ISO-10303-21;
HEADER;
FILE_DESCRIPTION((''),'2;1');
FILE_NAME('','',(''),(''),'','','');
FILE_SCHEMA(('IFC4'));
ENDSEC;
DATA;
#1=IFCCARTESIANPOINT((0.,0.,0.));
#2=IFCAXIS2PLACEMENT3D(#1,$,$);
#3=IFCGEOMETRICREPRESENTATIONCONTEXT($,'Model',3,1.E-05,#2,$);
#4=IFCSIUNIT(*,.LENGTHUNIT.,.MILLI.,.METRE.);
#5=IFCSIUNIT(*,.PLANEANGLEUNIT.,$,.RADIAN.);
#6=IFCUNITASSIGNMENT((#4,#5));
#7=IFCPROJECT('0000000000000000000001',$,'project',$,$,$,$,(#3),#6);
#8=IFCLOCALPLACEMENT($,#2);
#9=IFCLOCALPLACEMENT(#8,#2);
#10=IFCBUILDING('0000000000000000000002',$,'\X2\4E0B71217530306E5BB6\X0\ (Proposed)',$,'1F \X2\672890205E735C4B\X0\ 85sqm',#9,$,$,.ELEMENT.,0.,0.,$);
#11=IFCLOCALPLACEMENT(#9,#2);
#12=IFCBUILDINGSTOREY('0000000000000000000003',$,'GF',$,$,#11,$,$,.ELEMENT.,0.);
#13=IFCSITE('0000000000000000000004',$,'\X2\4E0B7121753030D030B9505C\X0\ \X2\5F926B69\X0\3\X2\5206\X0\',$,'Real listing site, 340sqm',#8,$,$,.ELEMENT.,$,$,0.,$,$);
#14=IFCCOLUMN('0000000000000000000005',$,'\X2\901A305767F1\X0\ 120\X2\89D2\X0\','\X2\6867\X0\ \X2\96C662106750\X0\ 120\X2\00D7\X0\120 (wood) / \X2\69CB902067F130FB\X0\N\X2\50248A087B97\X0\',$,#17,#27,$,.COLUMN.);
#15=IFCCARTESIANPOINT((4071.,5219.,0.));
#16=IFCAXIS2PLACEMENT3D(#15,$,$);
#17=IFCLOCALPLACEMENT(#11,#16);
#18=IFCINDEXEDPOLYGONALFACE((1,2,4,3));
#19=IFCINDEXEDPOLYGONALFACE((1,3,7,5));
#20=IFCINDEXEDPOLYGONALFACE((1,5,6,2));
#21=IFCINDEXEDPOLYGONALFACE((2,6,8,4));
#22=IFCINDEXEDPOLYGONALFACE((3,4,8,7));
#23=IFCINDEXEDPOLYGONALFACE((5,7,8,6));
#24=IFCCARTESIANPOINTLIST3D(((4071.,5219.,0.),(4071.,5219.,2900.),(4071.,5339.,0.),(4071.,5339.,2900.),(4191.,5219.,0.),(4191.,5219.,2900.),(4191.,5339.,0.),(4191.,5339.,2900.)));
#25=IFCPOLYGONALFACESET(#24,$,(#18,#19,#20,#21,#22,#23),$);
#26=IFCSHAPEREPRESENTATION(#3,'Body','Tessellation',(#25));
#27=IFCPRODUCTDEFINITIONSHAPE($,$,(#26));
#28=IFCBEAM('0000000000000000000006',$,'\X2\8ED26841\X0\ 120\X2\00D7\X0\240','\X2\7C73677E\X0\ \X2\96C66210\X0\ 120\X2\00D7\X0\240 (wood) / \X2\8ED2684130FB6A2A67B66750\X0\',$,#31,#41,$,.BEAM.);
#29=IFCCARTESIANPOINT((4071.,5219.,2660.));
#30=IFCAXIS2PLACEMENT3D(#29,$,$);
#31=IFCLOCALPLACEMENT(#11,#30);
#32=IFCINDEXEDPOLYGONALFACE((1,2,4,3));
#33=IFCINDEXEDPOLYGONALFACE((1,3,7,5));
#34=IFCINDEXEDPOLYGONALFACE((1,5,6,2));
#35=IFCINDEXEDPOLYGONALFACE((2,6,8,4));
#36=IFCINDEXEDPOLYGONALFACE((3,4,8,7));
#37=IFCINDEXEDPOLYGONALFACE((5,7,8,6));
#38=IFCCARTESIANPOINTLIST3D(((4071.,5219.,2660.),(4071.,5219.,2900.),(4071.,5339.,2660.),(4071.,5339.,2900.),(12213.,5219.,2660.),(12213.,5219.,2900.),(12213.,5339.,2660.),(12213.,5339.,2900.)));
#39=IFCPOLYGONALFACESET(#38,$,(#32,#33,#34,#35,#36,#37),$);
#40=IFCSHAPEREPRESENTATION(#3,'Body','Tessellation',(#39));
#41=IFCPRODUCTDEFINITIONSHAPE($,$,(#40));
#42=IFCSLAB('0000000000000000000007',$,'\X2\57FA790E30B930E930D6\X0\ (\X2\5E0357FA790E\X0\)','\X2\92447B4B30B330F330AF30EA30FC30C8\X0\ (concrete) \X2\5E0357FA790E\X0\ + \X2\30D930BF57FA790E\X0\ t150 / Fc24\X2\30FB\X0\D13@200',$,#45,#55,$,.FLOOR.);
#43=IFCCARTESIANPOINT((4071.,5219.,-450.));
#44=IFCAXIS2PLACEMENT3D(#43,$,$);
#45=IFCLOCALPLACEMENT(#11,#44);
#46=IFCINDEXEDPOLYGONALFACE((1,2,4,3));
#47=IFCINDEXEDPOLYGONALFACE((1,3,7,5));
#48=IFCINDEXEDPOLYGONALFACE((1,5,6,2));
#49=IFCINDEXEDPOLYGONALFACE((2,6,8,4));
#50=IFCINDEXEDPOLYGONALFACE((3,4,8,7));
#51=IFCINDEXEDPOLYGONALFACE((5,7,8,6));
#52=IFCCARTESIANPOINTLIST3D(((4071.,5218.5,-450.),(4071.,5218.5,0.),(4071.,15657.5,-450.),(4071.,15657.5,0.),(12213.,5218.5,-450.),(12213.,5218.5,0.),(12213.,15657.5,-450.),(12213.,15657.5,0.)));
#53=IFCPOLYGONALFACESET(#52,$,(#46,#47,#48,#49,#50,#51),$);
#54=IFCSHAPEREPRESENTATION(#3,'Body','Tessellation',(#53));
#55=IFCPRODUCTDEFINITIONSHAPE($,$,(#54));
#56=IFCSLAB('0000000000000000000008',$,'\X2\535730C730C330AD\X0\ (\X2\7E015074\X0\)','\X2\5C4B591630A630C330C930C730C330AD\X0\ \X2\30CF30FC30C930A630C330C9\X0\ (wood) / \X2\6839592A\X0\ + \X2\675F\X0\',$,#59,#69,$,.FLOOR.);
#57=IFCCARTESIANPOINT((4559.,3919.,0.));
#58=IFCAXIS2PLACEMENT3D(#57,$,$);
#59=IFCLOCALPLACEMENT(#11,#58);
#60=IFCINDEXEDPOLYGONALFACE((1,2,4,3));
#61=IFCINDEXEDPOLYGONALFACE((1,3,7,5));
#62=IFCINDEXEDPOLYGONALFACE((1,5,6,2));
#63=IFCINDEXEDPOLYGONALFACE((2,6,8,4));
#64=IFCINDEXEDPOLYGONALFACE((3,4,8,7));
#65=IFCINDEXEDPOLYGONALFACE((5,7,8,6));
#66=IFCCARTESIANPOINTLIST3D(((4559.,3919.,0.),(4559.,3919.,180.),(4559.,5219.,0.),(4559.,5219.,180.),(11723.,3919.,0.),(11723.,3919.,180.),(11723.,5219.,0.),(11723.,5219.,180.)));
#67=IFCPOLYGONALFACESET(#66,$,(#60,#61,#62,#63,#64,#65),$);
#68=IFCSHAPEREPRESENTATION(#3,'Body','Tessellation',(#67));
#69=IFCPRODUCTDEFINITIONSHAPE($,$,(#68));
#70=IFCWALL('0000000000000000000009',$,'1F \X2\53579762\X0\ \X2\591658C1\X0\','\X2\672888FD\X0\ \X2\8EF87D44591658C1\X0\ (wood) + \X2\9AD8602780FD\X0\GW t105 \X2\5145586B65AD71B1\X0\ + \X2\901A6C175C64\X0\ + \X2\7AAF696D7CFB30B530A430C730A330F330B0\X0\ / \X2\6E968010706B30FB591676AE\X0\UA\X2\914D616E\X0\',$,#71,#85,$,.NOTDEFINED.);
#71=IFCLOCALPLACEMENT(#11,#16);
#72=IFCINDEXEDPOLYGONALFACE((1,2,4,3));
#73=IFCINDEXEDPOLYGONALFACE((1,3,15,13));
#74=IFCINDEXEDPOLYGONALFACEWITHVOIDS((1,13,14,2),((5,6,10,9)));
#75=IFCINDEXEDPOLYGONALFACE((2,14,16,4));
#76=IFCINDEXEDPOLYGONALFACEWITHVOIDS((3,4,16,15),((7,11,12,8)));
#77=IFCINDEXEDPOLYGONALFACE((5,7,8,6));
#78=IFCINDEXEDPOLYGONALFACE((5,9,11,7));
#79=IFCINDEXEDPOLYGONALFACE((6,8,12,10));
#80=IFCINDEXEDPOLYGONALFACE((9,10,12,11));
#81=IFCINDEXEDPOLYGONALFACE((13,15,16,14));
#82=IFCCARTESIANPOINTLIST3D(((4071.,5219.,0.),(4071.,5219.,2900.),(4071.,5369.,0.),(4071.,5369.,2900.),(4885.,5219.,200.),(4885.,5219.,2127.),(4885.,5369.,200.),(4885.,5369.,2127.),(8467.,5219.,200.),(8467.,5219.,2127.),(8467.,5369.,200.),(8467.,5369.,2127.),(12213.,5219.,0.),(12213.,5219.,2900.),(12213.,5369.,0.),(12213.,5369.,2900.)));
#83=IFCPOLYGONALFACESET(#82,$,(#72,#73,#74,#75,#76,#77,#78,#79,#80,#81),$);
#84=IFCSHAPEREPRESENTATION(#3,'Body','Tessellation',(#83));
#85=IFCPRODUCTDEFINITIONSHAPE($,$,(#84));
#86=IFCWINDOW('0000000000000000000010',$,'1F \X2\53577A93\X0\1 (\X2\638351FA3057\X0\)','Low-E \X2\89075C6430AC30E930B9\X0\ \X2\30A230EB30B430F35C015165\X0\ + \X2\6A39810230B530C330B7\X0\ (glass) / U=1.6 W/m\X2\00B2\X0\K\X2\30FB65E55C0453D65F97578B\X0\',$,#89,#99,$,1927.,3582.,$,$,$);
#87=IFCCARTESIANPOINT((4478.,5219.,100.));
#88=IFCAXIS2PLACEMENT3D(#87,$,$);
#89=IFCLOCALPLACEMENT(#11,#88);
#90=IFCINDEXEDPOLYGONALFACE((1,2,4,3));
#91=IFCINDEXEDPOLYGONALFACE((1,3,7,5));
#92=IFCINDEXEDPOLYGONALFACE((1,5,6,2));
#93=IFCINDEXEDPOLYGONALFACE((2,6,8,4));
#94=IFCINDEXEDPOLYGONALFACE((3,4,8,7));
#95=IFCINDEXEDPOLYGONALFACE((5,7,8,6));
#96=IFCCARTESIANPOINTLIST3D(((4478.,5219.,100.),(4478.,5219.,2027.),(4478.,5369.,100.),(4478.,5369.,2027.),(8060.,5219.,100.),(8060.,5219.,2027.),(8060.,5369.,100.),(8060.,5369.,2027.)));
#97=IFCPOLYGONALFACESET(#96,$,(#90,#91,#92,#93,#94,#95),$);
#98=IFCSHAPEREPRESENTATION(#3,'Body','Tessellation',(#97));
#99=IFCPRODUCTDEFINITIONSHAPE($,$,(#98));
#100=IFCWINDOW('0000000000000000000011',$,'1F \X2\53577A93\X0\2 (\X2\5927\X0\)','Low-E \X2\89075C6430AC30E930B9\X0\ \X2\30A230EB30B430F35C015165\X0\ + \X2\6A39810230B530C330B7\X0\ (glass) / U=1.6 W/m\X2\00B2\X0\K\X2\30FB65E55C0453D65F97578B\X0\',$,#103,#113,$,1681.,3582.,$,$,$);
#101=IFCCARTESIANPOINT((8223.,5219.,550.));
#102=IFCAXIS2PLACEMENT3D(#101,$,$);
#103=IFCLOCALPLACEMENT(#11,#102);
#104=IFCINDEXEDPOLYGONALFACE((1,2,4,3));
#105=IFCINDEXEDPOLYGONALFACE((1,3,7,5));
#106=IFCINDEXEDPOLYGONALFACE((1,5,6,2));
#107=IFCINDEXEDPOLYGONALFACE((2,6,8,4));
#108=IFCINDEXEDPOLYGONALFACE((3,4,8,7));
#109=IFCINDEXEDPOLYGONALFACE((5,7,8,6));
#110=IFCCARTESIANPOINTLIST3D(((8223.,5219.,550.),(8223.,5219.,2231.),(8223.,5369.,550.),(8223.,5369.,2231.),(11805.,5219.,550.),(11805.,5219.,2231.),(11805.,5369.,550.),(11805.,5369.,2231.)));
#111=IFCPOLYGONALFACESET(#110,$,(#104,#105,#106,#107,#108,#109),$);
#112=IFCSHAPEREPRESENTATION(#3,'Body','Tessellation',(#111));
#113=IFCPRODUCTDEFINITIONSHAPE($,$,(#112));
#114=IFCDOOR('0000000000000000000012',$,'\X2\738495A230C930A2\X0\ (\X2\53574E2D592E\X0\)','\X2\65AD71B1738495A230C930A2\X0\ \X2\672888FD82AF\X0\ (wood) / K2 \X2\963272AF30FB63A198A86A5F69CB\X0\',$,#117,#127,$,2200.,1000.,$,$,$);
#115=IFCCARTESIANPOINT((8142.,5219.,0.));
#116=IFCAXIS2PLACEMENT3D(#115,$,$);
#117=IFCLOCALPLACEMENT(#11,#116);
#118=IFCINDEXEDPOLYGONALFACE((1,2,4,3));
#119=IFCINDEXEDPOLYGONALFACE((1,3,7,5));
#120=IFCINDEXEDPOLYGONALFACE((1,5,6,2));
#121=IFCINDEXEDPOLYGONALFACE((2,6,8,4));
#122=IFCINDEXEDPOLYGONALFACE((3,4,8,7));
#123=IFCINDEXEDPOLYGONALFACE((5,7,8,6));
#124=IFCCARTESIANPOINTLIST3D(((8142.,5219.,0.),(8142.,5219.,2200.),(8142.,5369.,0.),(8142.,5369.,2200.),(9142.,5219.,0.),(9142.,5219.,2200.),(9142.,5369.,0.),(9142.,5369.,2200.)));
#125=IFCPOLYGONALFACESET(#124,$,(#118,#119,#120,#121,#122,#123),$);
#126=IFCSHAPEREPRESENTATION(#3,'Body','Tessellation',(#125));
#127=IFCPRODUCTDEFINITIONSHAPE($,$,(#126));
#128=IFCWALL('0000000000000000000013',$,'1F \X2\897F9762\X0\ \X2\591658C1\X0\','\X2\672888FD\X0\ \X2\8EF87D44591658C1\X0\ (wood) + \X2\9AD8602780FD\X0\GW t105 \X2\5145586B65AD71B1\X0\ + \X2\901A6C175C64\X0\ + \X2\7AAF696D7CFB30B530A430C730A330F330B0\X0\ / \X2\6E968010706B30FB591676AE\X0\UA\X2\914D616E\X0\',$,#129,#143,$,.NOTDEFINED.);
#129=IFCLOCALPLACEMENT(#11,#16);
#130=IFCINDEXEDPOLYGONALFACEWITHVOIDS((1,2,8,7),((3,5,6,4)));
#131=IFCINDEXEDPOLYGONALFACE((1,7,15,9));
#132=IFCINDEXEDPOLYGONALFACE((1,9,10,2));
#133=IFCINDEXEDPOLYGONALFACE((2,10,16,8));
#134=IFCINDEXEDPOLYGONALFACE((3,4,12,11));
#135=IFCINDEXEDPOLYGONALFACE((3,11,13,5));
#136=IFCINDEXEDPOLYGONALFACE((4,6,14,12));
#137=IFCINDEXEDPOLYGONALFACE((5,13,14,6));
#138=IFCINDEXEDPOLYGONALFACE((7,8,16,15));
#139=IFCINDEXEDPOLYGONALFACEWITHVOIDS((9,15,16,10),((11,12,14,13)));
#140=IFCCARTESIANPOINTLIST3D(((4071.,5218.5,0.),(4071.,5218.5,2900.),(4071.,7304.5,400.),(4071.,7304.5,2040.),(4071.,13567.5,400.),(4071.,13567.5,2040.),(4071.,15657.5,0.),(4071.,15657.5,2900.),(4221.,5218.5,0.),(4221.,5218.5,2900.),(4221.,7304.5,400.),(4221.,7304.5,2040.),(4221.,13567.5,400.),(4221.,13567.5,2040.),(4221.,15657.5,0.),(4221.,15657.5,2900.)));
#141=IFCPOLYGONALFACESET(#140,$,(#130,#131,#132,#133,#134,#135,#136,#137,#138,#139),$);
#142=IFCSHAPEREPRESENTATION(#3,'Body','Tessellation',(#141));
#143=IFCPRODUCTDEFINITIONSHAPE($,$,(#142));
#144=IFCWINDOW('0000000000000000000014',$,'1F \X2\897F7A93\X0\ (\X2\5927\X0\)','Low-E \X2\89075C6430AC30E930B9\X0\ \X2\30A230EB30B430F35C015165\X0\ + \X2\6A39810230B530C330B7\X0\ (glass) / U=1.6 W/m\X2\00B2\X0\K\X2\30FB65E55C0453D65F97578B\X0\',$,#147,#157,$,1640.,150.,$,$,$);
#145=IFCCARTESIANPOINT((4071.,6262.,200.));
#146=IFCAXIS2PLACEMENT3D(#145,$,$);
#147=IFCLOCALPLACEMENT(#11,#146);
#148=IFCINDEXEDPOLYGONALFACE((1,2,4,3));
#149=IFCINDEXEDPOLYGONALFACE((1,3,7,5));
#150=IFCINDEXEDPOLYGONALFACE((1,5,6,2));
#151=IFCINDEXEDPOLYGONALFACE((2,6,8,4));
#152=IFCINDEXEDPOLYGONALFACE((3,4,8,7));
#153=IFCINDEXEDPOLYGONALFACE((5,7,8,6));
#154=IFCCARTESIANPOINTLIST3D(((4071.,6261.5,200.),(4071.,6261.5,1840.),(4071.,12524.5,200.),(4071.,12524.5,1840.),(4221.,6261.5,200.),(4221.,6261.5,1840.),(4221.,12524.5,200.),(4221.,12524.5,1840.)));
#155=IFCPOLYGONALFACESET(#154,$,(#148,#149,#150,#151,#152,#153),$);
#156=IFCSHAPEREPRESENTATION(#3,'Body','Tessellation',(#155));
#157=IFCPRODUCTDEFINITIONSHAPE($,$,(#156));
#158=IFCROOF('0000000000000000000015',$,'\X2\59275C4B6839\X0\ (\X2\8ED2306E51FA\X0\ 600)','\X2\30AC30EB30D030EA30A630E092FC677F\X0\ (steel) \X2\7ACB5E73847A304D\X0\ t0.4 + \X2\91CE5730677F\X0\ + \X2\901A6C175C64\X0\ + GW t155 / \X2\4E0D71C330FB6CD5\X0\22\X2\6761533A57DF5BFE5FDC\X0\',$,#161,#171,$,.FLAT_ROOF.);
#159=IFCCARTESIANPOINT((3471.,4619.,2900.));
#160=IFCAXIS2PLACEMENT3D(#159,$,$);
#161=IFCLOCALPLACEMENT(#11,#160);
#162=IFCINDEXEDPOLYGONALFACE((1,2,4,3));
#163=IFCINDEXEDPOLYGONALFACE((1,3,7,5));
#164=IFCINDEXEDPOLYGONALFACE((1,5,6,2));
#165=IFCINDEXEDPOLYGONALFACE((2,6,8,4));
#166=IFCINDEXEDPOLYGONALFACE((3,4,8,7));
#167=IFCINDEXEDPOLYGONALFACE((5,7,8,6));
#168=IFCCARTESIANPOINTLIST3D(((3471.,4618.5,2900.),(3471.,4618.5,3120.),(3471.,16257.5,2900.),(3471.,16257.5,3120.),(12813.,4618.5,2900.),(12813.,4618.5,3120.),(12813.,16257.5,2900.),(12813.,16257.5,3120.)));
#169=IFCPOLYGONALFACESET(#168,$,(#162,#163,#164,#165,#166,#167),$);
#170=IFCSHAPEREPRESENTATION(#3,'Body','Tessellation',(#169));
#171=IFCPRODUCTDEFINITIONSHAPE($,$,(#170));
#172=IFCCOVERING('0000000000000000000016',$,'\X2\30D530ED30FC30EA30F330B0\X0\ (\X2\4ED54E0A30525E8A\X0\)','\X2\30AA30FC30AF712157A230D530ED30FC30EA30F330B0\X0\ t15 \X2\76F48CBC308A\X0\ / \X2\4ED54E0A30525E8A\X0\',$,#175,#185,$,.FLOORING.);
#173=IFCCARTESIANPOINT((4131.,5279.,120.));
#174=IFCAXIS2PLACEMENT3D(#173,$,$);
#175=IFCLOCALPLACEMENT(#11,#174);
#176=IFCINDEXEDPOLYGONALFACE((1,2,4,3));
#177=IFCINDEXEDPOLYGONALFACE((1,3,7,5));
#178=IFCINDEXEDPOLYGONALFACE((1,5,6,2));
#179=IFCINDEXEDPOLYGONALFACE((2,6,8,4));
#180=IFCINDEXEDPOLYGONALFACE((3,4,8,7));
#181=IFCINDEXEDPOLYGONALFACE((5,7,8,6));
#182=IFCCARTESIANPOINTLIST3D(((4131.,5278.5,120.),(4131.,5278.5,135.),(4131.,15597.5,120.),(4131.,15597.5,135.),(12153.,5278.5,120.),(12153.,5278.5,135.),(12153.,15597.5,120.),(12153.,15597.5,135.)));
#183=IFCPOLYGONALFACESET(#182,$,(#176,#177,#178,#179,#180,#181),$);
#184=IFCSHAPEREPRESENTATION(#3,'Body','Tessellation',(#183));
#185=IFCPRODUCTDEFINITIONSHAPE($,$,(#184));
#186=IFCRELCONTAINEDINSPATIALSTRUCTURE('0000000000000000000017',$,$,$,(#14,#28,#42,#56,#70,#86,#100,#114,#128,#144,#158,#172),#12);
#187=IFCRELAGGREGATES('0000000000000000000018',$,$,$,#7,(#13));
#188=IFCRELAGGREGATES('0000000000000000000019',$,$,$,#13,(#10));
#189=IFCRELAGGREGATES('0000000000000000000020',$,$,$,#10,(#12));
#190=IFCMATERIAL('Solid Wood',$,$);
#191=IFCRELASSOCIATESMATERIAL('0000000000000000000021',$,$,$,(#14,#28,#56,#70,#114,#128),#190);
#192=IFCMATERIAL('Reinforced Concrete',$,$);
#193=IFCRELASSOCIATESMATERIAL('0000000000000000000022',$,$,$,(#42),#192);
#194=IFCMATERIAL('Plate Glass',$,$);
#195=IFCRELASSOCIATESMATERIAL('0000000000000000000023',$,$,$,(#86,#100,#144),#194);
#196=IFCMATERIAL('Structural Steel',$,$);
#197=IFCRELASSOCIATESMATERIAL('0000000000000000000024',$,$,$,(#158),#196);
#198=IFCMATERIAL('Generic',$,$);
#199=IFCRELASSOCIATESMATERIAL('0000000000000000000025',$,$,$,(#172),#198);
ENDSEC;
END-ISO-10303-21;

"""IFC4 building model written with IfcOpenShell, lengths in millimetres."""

from ifc_helpers import new_model, si_unit, frame, frame_2d, origin, place, context, project, spatial, rectangle, extrude, material, element, fill, save


model = new_model("IFC4")

# Units and contexts
model_context = context("Model", 3, precision=1e-05, world=origin())
ifc_project = project(units=[si_unit("LENGTHUNIT", "METRE", prefix="MILLI"), si_unit("PLANEANGLEUNIT", "RADIAN")], contexts=[model_context])

# Site, building, storey
site_placement = place(None, origin())
site = spatial("IfcSite", under=ifc_project, at=site_placement, Name="下無田バス停 徒歩3分", ObjectType="Real listing site, 340sqm", CompositionType="ELEMENT", RefElevation=0.0)
building_placement = place(site_placement, origin())
building = spatial("IfcBuilding", under=site, at=building_placement, Name="下無田の家 (Proposed)", ObjectType="1F 木造平屋 85sqm", CompositionType="ELEMENT", ElevationOfRefHeight=0.0, ElevationOfTerrain=0.0)
storey_placement = place(building_placement, origin())
storey = spatial("IfcBuildingStorey", under=building, at=storey_placement, Name="GF", CompositionType="ELEMENT", Elevation=0.0)

# Column
ifc_material_1 = material(Name="Solid Wood")
column_1_placement = place(storey_placement, frame((4071.0, 5219.0, 0.0)))
element("IfcColumn", 1, at=column_1_placement, inside=storey, material=ifc_material_1, Name="通し柱 120角", Description="桧 集成材 120×120 (wood) / 構造柱・N値計算", PredefinedType="COLUMN", context=model_context, shape_type="SweptSolid", body=[
    extrude(rectangle(XDim=120.0, YDim=120.0, at=frame_2d((60.0, 60.0))), frame((4071.0, 5219.0, 0.0)), (0.0, 0.0, 1.0), 2900.0),
])

# Beam
beam_1_placement = place(storey_placement, frame((4071.0, 5219.0, 2660.0)))
element("IfcBeam", 2, at=beam_1_placement, inside=storey, material=ifc_material_1, Name="軒桁 120×240", Description="米松 集成 120×240 (wood) / 軒桁・横架材", PredefinedType="BEAM", context=model_context, shape_type="SweptSolid", body=[
    extrude(rectangle(XDim=8142.0, YDim=120.0, at=frame_2d((4071.0, 60.0))), frame((4071.0, 5219.0, 2660.0)), (0.0, 0.0, 1.0), 240.0),
])

# Slabs
ifc_material_2 = material(Name="Reinforced Concrete")
slab_1_placement = place(storey_placement, frame((4071.0, 5219.0, -450.0)))
element("IfcSlab", 3, at=slab_1_placement, inside=storey, material=ifc_material_2, Name="基礎スラブ (布基礎)", Description="鉄筋コンクリート (concrete) 布基礎 + ベタ基礎 t150 / Fc24・D13@200", PredefinedType="FLOOR", context=model_context, shape_type="SweptSolid", body=[
    extrude(rectangle(XDim=8142.0, YDim=10439.0, at=frame_2d((4071.0, 5219.0))), frame((4071.0, 5219.0, -450.0)), (0.0, 0.0, 1.0), 450.0),
])
slab_2_placement = place(storey_placement, frame((4559.0, 3919.0, 0.0)))
element("IfcSlab", 4, at=slab_2_placement, inside=storey, material=ifc_material_1, Name="南デッキ (縁側)", Description="屋外ウッドデッキ ハードウッド (wood) / 根太 + 束", PredefinedType="FLOOR", context=model_context, shape_type="SweptSolid", body=[
    extrude(rectangle(XDim=7164.0, YDim=1300.0, at=frame_2d((3582.0, 650.0))), frame((4559.0, 3919.0, 0.0)), (0.0, 0.0, 1.0), 180.0),
])

# Wall, openings, windows, door
wall_1_placement = place(storey_placement, frame((4071.0, 5219.0, 0.0)))
wall_1 = element("IfcWall", 5, at=wall_1_placement, inside=storey, material=ifc_material_1, Name="1F 南面 外壁", Description="木製 軸組外壁 (wood) + 高性能GW t105 充填断熱 + 通気層 + 窯業系サイディング / 準耐火・外皮UA配慮", PredefinedType="NOTDEFINED", context=model_context, shape_type="SweptSolid", body=[
    extrude(rectangle(XDim=8142.0, YDim=150.0, at=frame_2d((4071.0, 75.0))), frame((4071.0, 5219.0, 0.0)), (0.0, 0.0, 1.0), 2900.0),
])
opening_1_placement = place(storey_placement, frame((4478.0, 5219.0, 100.0)))
opening_1 = element("IfcOpeningElement", 6, at=opening_1_placement, cuts=wall_1, PredefinedType="NOTDEFINED", context=model_context, shape_type="SweptSolid", body=[
    extrude(rectangle(XDim=3582.0, YDim=150.0, at=frame_2d((1791.0, 75.0))), frame((4478.0, 5219.0, 100.0)), (0.0, 0.0, 1.0), 1927.0),
])
opening_2_placement = place(storey_placement, frame((8223.0, 5219.0, 550.0)))
opening_2 = element("IfcOpeningElement", 7, at=opening_2_placement, cuts=wall_1, PredefinedType="NOTDEFINED", context=model_context, shape_type="SweptSolid", body=[
    extrude(rectangle(XDim=3582.0, YDim=150.0, at=frame_2d((1791.0, 75.0))), frame((8223.0, 5219.0, 550.0)), (0.0, 0.0, 1.0), 1681.0),
])
opening_3_placement = place(storey_placement, frame((8142.0, 5219.0, 0.0)))
opening_3 = element("IfcOpeningElement", 8, at=opening_3_placement, cuts=wall_1, PredefinedType="NOTDEFINED", context=model_context, shape_type="SweptSolid", body=[
    extrude(rectangle(XDim=1000.0, YDim=150.0, at=frame_2d((500.0, 75.0))), frame((8142.0, 5219.0, 0.0)), (0.0, 0.0, 1.0), 2200.0),
])
ifc_material_3 = material(Name="Plate Glass")
window_1_placement = place(storey_placement, frame((4478.0, 5219.0, 100.0)))
window_1 = element("IfcWindow", 9, at=window_1_placement, inside=storey, material=ifc_material_3, Name="1F 南窓1 (掃出し)", Description="Low-E 複層ガラス アルゴン封入 + 樹脂サッシ (glass) / U=1.6 W/m²K・日射取得型", OverallHeight=1927.0, OverallWidth=3582.0, context=model_context, shape_type="SweptSolid", body=[
    extrude(rectangle(XDim=3582.0, YDim=150.0, at=frame_2d((1791.0, 75.0))), frame((4478.0, 5219.0, 100.0)), (0.0, 0.0, 1.0), 1927.0),
])
fill(opening_1, window_1)
window_2_placement = place(storey_placement, frame((8223.0, 5219.0, 550.0)))
window_2 = element("IfcWindow", 10, at=window_2_placement, inside=storey, material=ifc_material_3, Name="1F 南窓2 (大)", Description="Low-E 複層ガラス アルゴン封入 + 樹脂サッシ (glass) / U=1.6 W/m²K・日射取得型", OverallHeight=1681.0, OverallWidth=3582.0, context=model_context, shape_type="SweptSolid", body=[
    extrude(rectangle(XDim=3582.0, YDim=150.0, at=frame_2d((1791.0, 75.0))), frame((8223.0, 5219.0, 550.0)), (0.0, 0.0, 1.0), 1681.0),
])
fill(opening_2, window_2)
door_placement = place(storey_placement, frame((8142.0, 5219.0, 0.0)))
door = element("IfcDoor", 11, at=door_placement, inside=storey, material=ifc_material_1, Name="玄関ドア (南中央)", Description="断熱玄関ドア 木製芯 (wood) / K2 防犯・採風機構", OverallHeight=2200.0, OverallWidth=1000.0, context=model_context, shape_type="SweptSolid", body=[
    extrude(rectangle(XDim=1000.0, YDim=150.0, at=frame_2d((500.0, 75.0))), frame((8142.0, 5219.0, 0.0)), (0.0, 0.0, 1.0), 2200.0),
])
fill(opening_3, door)

# Wall, opening, window
wall_2_placement = place(storey_placement, frame((4071.0, 5219.0, 0.0)))
wall_2 = element("IfcWall", 12, at=wall_2_placement, inside=storey, material=ifc_material_1, Name="1F 西面 外壁", Description="木製 軸組外壁 (wood) + 高性能GW t105 充填断熱 + 通気層 + 窯業系サイディング / 準耐火・外皮UA配慮", PredefinedType="NOTDEFINED", context=model_context, shape_type="SweptSolid", body=[
    extrude(rectangle(XDim=150.0, YDim=10439.0, at=frame_2d((75.0, 5219.0))), frame((4071.0, 5219.0, 0.0)), (0.0, 0.0, 1.0), 2900.0),
])
opening_4_placement = place(storey_placement, frame((4071.0, 6262.0, 200.0)))
opening_4 = element("IfcOpeningElement", 13, at=opening_4_placement, cuts=wall_2, PredefinedType="NOTDEFINED", context=model_context, shape_type="SweptSolid", body=[
    extrude(rectangle(XDim=150.0, YDim=6263.0, at=frame_2d((75.0, 3131.0))), frame((4071.0, 6262.0, 200.0)), (0.0, 0.0, 1.0), 1640.0),
])
window_3_placement = place(storey_placement, frame((4071.0, 6262.0, 200.0)))
window_3 = element("IfcWindow", 14, at=window_3_placement, inside=storey, material=ifc_material_3, Name="1F 西窓 (大)", Description="Low-E 複層ガラス アルゴン封入 + 樹脂サッシ (glass) / U=1.6 W/m²K・日射取得型", OverallHeight=1640.0, OverallWidth=150.0, context=model_context, shape_type="SweptSolid", body=[
    extrude(rectangle(XDim=150.0, YDim=6263.0, at=frame_2d((75.0, 3131.0))), frame((4071.0, 6262.0, 200.0)), (0.0, 0.0, 1.0), 1640.0),
])
fill(opening_4, window_3)

# Roof
ifc_material_4 = material(Name="Structural Steel")
roof_placement = place(storey_placement, frame((3471.0, 4619.0, 2900.0)))
element("IfcRoof", 15, at=roof_placement, inside=storey, material=ifc_material_4, Name="大屋根 (軒の出 600)", Description="ガルバリウム鋼板 (steel) 立平葺き t0.4 + 野地板 + 通気層 + GW t155 / 不燃・法22条区域対応", PredefinedType="FLAT_ROOF", context=model_context, shape_type="SweptSolid", body=[
    extrude(rectangle(XDim=9342.0, YDim=11639.0, at=frame_2d((4671.0, 5819.0))), frame((3471.0, 4619.0, 2900.0)), (0.0, 0.0, 1.0), 220.0),
])

# Covering
ifc_material_5 = material(Name="Generic")
covering_1_placement = place(storey_placement, frame((4131.0, 5279.0, 120.0)))
element("IfcCovering", 16, at=covering_1_placement, inside=storey, material=ifc_material_5, Name="フローリング (仕上げ床)", Description="オーク無垢フローリング t15 直貼り / 仕上げ床", PredefinedType="FLOORING", context=model_context, shape_type="SweptSolid", body=[
    extrude(rectangle(XDim=8022.0, YDim=10319.0, at=frame_2d((4011.0, 5159.0))), frame((4131.0, 5279.0, 120.0)), (0.0, 0.0, 1.0), 15.0),
])

save(model, "model.ifc")
